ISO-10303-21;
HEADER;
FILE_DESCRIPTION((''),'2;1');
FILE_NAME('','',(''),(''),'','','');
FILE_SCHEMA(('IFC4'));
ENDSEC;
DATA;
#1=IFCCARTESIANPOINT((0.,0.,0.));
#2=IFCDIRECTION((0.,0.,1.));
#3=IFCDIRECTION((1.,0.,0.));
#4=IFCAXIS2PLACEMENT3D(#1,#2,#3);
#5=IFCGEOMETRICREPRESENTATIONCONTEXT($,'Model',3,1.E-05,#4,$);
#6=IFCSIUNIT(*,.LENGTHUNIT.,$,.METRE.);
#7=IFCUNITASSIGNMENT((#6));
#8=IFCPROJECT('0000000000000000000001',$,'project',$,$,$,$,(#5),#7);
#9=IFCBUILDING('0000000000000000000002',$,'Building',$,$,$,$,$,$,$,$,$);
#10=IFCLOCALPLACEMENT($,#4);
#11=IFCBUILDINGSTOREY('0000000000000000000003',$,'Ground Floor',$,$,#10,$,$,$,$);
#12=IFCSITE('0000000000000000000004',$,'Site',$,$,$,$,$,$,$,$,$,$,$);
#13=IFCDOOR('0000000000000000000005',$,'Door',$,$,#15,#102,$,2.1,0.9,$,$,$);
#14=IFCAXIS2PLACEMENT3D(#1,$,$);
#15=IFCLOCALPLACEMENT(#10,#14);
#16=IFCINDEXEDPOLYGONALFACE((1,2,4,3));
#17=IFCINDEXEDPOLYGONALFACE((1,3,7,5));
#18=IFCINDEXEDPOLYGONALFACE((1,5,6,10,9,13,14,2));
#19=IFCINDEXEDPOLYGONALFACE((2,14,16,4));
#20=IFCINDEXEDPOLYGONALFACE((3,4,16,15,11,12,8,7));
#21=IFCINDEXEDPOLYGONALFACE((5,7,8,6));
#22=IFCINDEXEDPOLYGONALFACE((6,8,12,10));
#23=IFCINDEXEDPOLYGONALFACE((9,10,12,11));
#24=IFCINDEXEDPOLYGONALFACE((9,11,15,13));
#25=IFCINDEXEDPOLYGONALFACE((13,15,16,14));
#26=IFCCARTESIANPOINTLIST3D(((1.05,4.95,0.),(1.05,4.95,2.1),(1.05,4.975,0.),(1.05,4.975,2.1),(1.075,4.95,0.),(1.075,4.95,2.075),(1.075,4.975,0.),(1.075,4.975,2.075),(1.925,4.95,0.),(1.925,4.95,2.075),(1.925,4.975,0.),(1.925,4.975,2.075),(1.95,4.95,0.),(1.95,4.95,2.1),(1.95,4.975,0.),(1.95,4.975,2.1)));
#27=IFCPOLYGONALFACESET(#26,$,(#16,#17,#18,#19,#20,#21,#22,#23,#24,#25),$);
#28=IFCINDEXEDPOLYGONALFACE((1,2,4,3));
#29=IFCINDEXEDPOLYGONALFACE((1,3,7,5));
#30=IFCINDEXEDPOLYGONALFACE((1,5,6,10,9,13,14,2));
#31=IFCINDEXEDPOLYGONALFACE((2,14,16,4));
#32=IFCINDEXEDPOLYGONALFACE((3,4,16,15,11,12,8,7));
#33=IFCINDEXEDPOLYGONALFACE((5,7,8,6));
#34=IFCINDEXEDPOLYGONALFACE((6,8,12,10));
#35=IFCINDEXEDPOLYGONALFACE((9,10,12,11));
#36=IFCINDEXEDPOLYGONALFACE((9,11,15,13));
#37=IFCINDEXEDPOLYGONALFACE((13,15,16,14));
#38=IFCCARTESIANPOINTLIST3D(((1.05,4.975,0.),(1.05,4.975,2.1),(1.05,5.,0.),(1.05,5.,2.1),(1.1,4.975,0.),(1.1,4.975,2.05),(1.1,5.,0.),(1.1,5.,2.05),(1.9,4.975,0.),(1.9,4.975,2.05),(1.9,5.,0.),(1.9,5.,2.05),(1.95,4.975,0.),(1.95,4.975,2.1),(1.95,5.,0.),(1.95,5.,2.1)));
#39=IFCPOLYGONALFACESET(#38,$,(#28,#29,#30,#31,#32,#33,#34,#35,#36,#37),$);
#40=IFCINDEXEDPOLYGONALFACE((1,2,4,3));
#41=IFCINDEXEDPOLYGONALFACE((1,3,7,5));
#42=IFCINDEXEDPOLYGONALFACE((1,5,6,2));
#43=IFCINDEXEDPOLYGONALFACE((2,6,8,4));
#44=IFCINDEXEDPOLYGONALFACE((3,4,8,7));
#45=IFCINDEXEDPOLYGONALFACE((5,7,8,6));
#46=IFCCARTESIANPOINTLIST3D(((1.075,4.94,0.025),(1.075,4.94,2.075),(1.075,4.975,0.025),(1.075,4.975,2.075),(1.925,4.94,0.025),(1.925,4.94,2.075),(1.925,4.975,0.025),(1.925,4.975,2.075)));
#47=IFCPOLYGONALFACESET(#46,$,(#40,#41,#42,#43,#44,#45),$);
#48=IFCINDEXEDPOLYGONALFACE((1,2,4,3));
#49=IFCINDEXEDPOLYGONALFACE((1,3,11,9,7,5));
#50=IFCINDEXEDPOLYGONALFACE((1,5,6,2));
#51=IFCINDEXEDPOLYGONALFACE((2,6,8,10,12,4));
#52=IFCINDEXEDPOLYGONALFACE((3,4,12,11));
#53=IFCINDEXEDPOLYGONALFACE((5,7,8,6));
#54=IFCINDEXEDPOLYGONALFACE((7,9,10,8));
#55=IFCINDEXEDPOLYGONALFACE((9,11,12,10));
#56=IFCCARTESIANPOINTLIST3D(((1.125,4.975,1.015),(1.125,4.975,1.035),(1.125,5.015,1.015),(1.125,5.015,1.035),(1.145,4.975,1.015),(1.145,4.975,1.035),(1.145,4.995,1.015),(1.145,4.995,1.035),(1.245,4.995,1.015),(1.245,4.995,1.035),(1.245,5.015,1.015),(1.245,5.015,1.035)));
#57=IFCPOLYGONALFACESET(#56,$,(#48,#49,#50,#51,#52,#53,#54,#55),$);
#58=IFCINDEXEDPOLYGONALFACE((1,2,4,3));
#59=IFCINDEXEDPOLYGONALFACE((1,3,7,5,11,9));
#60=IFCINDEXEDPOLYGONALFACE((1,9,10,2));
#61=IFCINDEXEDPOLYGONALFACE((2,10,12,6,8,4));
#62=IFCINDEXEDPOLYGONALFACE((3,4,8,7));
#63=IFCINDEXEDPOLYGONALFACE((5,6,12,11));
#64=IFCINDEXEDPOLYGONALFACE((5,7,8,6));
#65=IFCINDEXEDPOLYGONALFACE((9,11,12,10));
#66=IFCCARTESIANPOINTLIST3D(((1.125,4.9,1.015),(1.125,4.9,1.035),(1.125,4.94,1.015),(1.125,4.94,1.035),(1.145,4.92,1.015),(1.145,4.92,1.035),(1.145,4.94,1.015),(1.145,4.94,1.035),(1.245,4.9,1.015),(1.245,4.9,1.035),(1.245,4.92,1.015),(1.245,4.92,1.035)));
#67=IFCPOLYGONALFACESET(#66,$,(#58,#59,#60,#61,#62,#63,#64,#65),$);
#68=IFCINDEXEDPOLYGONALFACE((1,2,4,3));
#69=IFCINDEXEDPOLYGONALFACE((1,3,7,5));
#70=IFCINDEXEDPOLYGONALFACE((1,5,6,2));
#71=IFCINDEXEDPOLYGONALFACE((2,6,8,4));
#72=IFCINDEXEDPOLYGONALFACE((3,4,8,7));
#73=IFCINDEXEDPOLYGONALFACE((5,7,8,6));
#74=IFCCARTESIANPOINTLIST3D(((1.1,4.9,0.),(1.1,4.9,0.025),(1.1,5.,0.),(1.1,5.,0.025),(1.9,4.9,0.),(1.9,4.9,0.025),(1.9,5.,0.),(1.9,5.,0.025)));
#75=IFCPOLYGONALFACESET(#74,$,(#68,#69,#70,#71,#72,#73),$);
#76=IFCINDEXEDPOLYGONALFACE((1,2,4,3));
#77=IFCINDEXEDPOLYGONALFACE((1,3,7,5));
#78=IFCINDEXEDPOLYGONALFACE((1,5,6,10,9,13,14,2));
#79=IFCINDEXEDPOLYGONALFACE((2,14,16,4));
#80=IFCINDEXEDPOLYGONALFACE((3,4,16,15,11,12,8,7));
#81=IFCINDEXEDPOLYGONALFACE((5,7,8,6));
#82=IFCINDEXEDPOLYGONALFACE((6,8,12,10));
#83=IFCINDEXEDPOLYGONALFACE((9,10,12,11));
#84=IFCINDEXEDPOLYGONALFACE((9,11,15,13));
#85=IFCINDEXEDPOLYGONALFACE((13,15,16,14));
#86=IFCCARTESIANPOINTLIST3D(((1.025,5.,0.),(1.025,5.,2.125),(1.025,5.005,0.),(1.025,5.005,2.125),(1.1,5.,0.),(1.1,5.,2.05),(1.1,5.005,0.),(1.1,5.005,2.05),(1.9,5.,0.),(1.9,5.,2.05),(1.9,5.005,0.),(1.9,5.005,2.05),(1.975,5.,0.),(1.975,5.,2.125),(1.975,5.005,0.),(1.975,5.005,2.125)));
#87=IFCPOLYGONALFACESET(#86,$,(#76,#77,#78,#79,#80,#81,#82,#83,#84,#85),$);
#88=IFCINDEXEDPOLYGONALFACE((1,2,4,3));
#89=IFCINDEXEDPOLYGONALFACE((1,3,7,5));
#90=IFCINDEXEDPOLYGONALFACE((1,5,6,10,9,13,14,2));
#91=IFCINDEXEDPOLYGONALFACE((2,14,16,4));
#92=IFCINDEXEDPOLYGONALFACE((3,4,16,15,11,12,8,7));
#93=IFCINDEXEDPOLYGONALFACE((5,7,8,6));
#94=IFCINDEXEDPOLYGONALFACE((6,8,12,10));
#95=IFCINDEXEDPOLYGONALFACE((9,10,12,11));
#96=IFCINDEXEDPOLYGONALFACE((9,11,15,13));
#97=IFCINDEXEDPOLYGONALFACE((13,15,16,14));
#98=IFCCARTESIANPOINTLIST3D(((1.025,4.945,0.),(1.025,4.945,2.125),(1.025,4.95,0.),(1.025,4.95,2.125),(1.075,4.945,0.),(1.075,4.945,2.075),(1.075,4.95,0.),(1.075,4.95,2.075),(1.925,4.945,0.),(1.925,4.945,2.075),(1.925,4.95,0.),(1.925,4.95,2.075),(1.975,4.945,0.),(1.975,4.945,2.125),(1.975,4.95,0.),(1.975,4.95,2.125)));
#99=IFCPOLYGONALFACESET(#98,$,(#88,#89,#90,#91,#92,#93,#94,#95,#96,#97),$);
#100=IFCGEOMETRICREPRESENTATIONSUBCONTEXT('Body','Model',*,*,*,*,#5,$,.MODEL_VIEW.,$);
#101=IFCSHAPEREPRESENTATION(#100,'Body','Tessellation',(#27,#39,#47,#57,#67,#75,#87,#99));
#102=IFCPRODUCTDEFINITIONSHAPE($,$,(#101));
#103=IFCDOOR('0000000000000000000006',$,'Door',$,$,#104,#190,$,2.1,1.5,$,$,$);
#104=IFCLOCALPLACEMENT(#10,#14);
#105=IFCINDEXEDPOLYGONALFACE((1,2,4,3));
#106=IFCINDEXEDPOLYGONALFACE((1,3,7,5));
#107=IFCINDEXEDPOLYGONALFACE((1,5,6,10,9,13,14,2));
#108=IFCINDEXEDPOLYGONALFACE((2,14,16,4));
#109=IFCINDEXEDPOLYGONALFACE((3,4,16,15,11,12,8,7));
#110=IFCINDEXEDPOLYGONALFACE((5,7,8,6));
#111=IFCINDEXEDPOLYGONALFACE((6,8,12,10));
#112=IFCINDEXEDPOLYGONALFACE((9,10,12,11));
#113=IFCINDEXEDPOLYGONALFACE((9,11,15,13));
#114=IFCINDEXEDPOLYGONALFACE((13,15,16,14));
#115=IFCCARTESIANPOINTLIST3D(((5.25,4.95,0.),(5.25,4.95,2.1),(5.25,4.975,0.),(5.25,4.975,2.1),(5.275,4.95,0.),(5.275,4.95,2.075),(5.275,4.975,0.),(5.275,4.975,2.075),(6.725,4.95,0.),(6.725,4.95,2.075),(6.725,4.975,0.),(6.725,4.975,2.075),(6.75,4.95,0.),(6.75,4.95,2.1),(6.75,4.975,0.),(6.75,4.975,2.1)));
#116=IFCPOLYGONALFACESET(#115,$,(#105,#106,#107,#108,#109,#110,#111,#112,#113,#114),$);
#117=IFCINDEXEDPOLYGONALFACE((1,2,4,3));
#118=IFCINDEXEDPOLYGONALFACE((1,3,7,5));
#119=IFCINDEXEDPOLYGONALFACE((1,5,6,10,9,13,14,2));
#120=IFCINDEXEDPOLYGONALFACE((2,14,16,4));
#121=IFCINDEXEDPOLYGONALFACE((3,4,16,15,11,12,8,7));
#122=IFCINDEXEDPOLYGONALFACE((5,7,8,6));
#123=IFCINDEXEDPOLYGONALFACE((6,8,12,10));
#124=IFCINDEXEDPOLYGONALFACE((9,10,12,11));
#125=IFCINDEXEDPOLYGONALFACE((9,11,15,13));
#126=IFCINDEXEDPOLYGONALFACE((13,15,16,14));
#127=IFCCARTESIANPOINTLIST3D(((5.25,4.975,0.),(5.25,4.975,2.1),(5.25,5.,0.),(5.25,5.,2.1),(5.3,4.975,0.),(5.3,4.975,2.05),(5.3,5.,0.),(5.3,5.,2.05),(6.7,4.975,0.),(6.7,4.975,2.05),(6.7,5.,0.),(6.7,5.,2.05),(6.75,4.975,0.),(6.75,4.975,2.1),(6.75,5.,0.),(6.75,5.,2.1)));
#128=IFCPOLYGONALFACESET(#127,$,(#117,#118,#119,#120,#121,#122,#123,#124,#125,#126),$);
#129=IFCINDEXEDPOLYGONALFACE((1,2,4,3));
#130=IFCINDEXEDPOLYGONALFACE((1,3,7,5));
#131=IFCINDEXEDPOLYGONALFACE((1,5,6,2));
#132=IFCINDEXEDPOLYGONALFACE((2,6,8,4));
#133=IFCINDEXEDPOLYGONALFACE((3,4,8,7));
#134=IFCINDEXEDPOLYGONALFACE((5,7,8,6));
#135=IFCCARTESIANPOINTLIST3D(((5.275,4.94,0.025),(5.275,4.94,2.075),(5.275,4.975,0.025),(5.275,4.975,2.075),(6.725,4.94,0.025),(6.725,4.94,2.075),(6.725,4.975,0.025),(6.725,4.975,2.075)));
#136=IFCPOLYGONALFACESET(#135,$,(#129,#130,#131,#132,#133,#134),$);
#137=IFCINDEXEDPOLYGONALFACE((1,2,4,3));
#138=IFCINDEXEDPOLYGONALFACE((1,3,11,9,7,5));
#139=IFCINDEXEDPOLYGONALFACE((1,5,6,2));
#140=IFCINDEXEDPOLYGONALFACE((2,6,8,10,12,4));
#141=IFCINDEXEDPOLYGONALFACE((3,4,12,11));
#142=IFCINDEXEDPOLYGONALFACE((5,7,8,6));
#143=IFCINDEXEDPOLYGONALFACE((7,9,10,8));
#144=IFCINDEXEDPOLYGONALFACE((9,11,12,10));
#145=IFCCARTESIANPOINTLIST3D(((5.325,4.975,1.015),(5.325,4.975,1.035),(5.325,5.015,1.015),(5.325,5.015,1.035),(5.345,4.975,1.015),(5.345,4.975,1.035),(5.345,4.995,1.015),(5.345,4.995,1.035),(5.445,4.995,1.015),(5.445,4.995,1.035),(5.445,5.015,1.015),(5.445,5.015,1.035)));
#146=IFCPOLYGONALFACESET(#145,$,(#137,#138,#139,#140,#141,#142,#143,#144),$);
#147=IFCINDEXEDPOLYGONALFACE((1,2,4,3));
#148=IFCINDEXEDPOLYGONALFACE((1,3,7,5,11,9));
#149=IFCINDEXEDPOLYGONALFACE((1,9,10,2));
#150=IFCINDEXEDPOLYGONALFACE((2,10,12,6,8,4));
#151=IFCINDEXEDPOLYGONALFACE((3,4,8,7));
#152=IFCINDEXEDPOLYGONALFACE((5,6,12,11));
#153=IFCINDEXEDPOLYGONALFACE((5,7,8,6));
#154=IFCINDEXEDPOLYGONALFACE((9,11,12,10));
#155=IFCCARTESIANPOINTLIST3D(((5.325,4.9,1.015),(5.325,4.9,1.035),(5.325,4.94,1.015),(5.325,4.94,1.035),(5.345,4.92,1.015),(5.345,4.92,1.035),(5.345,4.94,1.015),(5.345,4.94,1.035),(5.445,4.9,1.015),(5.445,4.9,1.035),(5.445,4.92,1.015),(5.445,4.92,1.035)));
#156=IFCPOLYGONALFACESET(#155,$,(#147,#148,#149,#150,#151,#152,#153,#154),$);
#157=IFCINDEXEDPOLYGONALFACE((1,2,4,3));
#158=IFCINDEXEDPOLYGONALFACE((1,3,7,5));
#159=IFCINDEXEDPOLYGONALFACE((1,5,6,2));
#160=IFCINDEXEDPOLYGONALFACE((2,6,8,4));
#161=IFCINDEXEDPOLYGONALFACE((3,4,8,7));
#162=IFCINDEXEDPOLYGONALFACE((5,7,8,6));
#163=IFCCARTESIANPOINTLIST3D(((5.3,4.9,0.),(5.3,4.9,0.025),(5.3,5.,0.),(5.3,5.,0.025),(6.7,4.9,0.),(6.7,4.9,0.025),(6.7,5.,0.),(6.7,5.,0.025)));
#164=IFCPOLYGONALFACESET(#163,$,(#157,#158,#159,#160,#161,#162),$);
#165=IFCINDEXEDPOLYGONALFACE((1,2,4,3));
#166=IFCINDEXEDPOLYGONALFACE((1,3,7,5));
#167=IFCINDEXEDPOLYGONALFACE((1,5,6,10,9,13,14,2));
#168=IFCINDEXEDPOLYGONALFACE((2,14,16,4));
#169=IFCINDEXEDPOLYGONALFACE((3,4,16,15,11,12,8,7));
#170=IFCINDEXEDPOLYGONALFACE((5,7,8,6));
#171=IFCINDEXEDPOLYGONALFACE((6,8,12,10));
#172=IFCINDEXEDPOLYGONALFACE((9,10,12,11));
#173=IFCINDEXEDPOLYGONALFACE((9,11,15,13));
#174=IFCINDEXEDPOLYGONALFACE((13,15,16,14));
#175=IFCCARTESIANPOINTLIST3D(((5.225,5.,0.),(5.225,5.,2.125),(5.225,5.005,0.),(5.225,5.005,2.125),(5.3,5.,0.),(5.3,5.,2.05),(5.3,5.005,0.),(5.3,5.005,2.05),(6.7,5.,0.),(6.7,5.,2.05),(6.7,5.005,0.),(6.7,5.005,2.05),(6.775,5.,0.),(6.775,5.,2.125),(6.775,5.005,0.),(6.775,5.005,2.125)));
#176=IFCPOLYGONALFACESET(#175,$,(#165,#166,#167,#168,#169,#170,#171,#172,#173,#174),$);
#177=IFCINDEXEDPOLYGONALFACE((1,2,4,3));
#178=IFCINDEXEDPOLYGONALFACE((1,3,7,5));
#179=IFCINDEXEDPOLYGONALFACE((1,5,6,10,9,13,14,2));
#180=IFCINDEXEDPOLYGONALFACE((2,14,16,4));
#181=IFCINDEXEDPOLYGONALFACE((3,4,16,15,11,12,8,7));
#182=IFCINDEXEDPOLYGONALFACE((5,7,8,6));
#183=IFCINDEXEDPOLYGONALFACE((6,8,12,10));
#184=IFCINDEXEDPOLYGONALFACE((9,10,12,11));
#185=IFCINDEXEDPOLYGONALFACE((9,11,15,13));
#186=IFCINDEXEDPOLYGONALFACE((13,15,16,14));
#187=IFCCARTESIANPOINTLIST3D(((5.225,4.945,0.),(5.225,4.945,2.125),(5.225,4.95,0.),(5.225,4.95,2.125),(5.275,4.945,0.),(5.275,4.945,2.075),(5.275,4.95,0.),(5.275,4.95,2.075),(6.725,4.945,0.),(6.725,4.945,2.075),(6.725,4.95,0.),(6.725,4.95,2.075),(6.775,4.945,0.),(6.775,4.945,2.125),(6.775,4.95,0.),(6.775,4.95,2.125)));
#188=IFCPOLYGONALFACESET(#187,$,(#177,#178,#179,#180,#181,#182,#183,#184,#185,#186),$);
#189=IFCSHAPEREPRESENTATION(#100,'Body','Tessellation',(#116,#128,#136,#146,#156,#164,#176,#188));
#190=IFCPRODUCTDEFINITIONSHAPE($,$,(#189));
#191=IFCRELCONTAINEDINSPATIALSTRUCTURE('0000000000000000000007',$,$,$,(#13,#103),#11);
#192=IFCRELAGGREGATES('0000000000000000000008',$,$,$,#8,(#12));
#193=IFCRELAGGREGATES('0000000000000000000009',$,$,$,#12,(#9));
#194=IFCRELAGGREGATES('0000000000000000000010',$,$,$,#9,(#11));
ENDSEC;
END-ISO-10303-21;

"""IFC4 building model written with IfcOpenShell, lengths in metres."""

from ifc_helpers import new_model, si_unit, frame, origin_with_axes, place, context, subcontext, project, spatial, line, indexed_curve, outline, extrude, element, save


model = new_model("IFC4")

# Units and contexts
model_context = context("Model", 3, precision=1e-05, world=origin_with_axes())
body_context = subcontext(model_context, "Body", "Model", "MODEL_VIEW")
ifc_project = project(units=[si_unit("LENGTHUNIT", "METRE")], contexts=[model_context])

# Site, building, storey
site = spatial("IfcSite", under=ifc_project, Name="Site")
building = spatial("IfcBuilding", under=site, Name="Building")
storey_placement = place(None, origin_with_axes())
storey = spatial("IfcBuildingStorey", under=building, at=storey_placement, Name="Ground Floor")

# Doors
door_1_placement = place(storey_placement, frame((1.95, 5.0, 0.0), z_axis=(0.0, 0.0, 1.0), x_axis=(-1.0, 0.0, 0.0)))
element("IfcDoor", 1, at=door_1_placement, inside=storey, Name="Door", OverallHeight=2.1, OverallWidth=0.9, context=body_context, shape_type="SweptSolid", body=[
    extrude(outline(indexed_curve([(0.0, 0.0), (0.0, 2.1), (0.9, 2.1), (0.9, 0.0), (0.875, 0.0), (0.875, 2.075), (0.025, 2.075), (0.025, 0.0)], segments=[line(1, 2, 3, 4, 5, 6, 7, 8, 1)])), frame((0.0, 0.025, 0.0), z_axis=(0.0, -1.0, 0.0), x_axis=(1.0, 0.0, 0.0)), (0.0, 0.0, -1.0), 0.025),
    extrude(outline(indexed_curve([(0.0, 0.0), (0.0, 2.1), (0.9, 2.1), (0.9, 0.0), (0.85, 0.0), (0.85, 2.05), (0.05, 2.05), (0.05, 0.0)], segments=[line(1, 2, 3, 4, 5, 6, 7, 8, 1)])), frame((0.0, 0.0, 0.0), z_axis=(0.0, -1.0, 0.0), x_axis=(1.0, 0.0, 0.0)), (0.0, 0.0, -1.0), 0.025),
    extrude(outline(indexed_curve([(0.0, 0.0), (0.85, 0.0), (0.85, 0.035), (0.0, 0.035)], segments=[line(1, 2, 3, 4, 1)])), frame((0.025, 0.025, 0.025), z_axis=(0.0, 0.0, 1.0), x_axis=(1.0, 0.0, 0.0)), (0.0, 0.0, 1.0), 2.05),
    extrude(outline(indexed_curve([(0.0, 0.0), (0.0, -0.04), (-0.12, -0.04), (-0.12, -0.02), (-0.02, -0.02), (-0.02, 0.0)], segments=[line(1, 2, 3, 4, 5, 6, 1)])), frame((0.825, 0.025, 1.015), z_axis=(0.0, 0.0, 1.0), x_axis=(1.0, 0.0, 0.0)), (0.0, 0.0, 1.0), 0.02),
    extrude(outline(indexed_curve([(0.0, 0.0), (0.0, 0.04), (-0.12, 0.04), (-0.12, 0.02), (-0.02, 0.02), (-0.02, 0.0)], segments=[line(1, 2, 3, 4, 5, 6, 1)])), frame((0.825, 0.06, 1.015), z_axis=(0.0, 0.0, 1.0), x_axis=(1.0, 0.0, 0.0)), (0.0, 0.0, 1.0), 0.02),
    extrude(outline(indexed_curve([(0.0, 0.0), (0.8, 0.0), (0.8, 0.1), (0.0, 0.1)], segments=[line(1, 2, 3, 4, 1)])), frame((0.05, 0.0, 0.0), z_axis=(0.0, 0.0, 1.0), x_axis=(1.0, 0.0, 0.0)), (0.0, 0.0, 1.0), 0.025),
    extrude(outline(indexed_curve([(0.0, 0.0), (0.0, 2.125), (0.95, 2.125), (0.95, 0.0), (0.875, 0.0), (0.875, 2.05), (0.075, 2.05), (0.075, 0.0)], segments=[line(1, 2, 3, 4, 5, 6, 7, 8, 1)])), frame((-0.025, -0.005, 0.0), z_axis=(0.0, -1.0, 0.0), x_axis=(1.0, 0.0, 0.0)), (0.0, 0.0, -1.0), 0.005),
    extrude(outline(indexed_curve([(0.0, 0.0), (0.0, 2.125), (0.95, 2.125), (0.95, 0.0), (0.9, 0.0), (0.9, 2.075), (0.05, 2.075), (0.05, 0.0)], segments=[line(1, 2, 3, 4, 5, 6, 7, 8, 1)])), frame((-0.025, 0.05, 0.0), z_axis=(0.0, -1.0, 0.0), x_axis=(1.0, 0.0, 0.0)), (0.0, 0.0, -1.0), 0.005),
])
door_2_placement = place(storey_placement, frame((6.75, 5.0, 0.0), z_axis=(0.0, 0.0, 1.0), x_axis=(-1.0, 0.0, 0.0)))
element("IfcDoor", 2, at=door_2_placement, inside=storey, Name="Door", OverallHeight=2.1, OverallWidth=1.5, context=body_context, shape_type="SweptSolid", body=[
    extrude(outline(indexed_curve([(0.0, 0.0), (0.0, 2.1), (1.5, 2.1), (1.5, 0.0), (1.475, 0.0), (1.475, 2.075), (0.025, 2.075), (0.025, 0.0)], segments=[line(1, 2, 3, 4, 5, 6, 7, 8, 1)])), frame((0.0, 0.025, 0.0), z_axis=(0.0, -1.0, 0.0), x_axis=(1.0, 0.0, 0.0)), (0.0, 0.0, -1.0), 0.025),
    extrude(outline(indexed_curve([(0.0, 0.0), (0.0, 2.1), (1.5, 2.1), (1.5, 0.0), (1.45, 0.0), (1.45, 2.05), (0.05, 2.05), (0.05, 0.0)], segments=[line(1, 2, 3, 4, 5, 6, 7, 8, 1)])), frame((0.0, 0.0, 0.0), z_axis=(0.0, -1.0, 0.0), x_axis=(1.0, 0.0, 0.0)), (0.0, 0.0, -1.0), 0.025),
    extrude(outline(indexed_curve([(0.0, 0.0), (1.45, 0.0), (1.45, 0.035), (0.0, 0.035)], segments=[line(1, 2, 3, 4, 1)])), frame((0.025, 0.025, 0.025), z_axis=(0.0, 0.0, 1.0), x_axis=(1.0, 0.0, 0.0)), (0.0, 0.0, 1.0), 2.05),
    extrude(outline(indexed_curve([(0.0, 0.0), (0.0, -0.04), (-0.12, -0.04), (-0.12, -0.02), (-0.02, -0.02), (-0.02, 0.0)], segments=[line(1, 2, 3, 4, 5, 6, 1)])), frame((1.425, 0.025, 1.015), z_axis=(0.0, 0.0, 1.0), x_axis=(1.0, 0.0, 0.0)), (0.0, 0.0, 1.0), 0.02),
    extrude(outline(indexed_curve([(0.0, 0.0), (0.0, 0.04), (-0.12, 0.04), (-0.12, 0.02), (-0.02, 0.02), (-0.02, 0.0)], segments=[line(1, 2, 3, 4, 5, 6, 1)])), frame((1.425, 0.06, 1.015), z_axis=(0.0, 0.0, 1.0), x_axis=(1.0, 0.0, 0.0)), (0.0, 0.0, 1.0), 0.02),
    extrude(outline(indexed_curve([(0.0, 0.0), (1.4, 0.0), (1.4, 0.1), (0.0, 0.1)], segments=[line(1, 2, 3, 4, 1)])), frame((0.05, 0.0, 0.0), z_axis=(0.0, 0.0, 1.0), x_axis=(1.0, 0.0, 0.0)), (0.0, 0.0, 1.0), 0.025),
    extrude(outline(indexed_curve([(0.0, 0.0), (0.0, 2.125), (1.55, 2.125), (1.55, 0.0), (1.475, 0.0), (1.475, 2.05), (0.075, 2.05), (0.075, 0.0)], segments=[line(1, 2, 3, 4, 5, 6, 7, 8, 1)])), frame((-0.025, -0.005, 0.0), z_axis=(0.0, -1.0, 0.0), x_axis=(1.0, 0.0, 0.0)), (0.0, 0.0, -1.0), 0.005),
    extrude(outline(indexed_curve([(0.0, 0.0), (0.0, 2.125), (1.55, 2.125), (1.55, 0.0), (1.5, 0.0), (1.5, 2.075), (0.05, 2.075), (0.05, 0.0)], segments=[line(1, 2, 3, 4, 5, 6, 7, 8, 1)])), frame((-0.025, 0.05, 0.0), z_axis=(0.0, -1.0, 0.0), x_axis=(1.0, 0.0, 0.0)), (0.0, 0.0, -1.0), 0.005),
])

save(model, "model.ifc")
